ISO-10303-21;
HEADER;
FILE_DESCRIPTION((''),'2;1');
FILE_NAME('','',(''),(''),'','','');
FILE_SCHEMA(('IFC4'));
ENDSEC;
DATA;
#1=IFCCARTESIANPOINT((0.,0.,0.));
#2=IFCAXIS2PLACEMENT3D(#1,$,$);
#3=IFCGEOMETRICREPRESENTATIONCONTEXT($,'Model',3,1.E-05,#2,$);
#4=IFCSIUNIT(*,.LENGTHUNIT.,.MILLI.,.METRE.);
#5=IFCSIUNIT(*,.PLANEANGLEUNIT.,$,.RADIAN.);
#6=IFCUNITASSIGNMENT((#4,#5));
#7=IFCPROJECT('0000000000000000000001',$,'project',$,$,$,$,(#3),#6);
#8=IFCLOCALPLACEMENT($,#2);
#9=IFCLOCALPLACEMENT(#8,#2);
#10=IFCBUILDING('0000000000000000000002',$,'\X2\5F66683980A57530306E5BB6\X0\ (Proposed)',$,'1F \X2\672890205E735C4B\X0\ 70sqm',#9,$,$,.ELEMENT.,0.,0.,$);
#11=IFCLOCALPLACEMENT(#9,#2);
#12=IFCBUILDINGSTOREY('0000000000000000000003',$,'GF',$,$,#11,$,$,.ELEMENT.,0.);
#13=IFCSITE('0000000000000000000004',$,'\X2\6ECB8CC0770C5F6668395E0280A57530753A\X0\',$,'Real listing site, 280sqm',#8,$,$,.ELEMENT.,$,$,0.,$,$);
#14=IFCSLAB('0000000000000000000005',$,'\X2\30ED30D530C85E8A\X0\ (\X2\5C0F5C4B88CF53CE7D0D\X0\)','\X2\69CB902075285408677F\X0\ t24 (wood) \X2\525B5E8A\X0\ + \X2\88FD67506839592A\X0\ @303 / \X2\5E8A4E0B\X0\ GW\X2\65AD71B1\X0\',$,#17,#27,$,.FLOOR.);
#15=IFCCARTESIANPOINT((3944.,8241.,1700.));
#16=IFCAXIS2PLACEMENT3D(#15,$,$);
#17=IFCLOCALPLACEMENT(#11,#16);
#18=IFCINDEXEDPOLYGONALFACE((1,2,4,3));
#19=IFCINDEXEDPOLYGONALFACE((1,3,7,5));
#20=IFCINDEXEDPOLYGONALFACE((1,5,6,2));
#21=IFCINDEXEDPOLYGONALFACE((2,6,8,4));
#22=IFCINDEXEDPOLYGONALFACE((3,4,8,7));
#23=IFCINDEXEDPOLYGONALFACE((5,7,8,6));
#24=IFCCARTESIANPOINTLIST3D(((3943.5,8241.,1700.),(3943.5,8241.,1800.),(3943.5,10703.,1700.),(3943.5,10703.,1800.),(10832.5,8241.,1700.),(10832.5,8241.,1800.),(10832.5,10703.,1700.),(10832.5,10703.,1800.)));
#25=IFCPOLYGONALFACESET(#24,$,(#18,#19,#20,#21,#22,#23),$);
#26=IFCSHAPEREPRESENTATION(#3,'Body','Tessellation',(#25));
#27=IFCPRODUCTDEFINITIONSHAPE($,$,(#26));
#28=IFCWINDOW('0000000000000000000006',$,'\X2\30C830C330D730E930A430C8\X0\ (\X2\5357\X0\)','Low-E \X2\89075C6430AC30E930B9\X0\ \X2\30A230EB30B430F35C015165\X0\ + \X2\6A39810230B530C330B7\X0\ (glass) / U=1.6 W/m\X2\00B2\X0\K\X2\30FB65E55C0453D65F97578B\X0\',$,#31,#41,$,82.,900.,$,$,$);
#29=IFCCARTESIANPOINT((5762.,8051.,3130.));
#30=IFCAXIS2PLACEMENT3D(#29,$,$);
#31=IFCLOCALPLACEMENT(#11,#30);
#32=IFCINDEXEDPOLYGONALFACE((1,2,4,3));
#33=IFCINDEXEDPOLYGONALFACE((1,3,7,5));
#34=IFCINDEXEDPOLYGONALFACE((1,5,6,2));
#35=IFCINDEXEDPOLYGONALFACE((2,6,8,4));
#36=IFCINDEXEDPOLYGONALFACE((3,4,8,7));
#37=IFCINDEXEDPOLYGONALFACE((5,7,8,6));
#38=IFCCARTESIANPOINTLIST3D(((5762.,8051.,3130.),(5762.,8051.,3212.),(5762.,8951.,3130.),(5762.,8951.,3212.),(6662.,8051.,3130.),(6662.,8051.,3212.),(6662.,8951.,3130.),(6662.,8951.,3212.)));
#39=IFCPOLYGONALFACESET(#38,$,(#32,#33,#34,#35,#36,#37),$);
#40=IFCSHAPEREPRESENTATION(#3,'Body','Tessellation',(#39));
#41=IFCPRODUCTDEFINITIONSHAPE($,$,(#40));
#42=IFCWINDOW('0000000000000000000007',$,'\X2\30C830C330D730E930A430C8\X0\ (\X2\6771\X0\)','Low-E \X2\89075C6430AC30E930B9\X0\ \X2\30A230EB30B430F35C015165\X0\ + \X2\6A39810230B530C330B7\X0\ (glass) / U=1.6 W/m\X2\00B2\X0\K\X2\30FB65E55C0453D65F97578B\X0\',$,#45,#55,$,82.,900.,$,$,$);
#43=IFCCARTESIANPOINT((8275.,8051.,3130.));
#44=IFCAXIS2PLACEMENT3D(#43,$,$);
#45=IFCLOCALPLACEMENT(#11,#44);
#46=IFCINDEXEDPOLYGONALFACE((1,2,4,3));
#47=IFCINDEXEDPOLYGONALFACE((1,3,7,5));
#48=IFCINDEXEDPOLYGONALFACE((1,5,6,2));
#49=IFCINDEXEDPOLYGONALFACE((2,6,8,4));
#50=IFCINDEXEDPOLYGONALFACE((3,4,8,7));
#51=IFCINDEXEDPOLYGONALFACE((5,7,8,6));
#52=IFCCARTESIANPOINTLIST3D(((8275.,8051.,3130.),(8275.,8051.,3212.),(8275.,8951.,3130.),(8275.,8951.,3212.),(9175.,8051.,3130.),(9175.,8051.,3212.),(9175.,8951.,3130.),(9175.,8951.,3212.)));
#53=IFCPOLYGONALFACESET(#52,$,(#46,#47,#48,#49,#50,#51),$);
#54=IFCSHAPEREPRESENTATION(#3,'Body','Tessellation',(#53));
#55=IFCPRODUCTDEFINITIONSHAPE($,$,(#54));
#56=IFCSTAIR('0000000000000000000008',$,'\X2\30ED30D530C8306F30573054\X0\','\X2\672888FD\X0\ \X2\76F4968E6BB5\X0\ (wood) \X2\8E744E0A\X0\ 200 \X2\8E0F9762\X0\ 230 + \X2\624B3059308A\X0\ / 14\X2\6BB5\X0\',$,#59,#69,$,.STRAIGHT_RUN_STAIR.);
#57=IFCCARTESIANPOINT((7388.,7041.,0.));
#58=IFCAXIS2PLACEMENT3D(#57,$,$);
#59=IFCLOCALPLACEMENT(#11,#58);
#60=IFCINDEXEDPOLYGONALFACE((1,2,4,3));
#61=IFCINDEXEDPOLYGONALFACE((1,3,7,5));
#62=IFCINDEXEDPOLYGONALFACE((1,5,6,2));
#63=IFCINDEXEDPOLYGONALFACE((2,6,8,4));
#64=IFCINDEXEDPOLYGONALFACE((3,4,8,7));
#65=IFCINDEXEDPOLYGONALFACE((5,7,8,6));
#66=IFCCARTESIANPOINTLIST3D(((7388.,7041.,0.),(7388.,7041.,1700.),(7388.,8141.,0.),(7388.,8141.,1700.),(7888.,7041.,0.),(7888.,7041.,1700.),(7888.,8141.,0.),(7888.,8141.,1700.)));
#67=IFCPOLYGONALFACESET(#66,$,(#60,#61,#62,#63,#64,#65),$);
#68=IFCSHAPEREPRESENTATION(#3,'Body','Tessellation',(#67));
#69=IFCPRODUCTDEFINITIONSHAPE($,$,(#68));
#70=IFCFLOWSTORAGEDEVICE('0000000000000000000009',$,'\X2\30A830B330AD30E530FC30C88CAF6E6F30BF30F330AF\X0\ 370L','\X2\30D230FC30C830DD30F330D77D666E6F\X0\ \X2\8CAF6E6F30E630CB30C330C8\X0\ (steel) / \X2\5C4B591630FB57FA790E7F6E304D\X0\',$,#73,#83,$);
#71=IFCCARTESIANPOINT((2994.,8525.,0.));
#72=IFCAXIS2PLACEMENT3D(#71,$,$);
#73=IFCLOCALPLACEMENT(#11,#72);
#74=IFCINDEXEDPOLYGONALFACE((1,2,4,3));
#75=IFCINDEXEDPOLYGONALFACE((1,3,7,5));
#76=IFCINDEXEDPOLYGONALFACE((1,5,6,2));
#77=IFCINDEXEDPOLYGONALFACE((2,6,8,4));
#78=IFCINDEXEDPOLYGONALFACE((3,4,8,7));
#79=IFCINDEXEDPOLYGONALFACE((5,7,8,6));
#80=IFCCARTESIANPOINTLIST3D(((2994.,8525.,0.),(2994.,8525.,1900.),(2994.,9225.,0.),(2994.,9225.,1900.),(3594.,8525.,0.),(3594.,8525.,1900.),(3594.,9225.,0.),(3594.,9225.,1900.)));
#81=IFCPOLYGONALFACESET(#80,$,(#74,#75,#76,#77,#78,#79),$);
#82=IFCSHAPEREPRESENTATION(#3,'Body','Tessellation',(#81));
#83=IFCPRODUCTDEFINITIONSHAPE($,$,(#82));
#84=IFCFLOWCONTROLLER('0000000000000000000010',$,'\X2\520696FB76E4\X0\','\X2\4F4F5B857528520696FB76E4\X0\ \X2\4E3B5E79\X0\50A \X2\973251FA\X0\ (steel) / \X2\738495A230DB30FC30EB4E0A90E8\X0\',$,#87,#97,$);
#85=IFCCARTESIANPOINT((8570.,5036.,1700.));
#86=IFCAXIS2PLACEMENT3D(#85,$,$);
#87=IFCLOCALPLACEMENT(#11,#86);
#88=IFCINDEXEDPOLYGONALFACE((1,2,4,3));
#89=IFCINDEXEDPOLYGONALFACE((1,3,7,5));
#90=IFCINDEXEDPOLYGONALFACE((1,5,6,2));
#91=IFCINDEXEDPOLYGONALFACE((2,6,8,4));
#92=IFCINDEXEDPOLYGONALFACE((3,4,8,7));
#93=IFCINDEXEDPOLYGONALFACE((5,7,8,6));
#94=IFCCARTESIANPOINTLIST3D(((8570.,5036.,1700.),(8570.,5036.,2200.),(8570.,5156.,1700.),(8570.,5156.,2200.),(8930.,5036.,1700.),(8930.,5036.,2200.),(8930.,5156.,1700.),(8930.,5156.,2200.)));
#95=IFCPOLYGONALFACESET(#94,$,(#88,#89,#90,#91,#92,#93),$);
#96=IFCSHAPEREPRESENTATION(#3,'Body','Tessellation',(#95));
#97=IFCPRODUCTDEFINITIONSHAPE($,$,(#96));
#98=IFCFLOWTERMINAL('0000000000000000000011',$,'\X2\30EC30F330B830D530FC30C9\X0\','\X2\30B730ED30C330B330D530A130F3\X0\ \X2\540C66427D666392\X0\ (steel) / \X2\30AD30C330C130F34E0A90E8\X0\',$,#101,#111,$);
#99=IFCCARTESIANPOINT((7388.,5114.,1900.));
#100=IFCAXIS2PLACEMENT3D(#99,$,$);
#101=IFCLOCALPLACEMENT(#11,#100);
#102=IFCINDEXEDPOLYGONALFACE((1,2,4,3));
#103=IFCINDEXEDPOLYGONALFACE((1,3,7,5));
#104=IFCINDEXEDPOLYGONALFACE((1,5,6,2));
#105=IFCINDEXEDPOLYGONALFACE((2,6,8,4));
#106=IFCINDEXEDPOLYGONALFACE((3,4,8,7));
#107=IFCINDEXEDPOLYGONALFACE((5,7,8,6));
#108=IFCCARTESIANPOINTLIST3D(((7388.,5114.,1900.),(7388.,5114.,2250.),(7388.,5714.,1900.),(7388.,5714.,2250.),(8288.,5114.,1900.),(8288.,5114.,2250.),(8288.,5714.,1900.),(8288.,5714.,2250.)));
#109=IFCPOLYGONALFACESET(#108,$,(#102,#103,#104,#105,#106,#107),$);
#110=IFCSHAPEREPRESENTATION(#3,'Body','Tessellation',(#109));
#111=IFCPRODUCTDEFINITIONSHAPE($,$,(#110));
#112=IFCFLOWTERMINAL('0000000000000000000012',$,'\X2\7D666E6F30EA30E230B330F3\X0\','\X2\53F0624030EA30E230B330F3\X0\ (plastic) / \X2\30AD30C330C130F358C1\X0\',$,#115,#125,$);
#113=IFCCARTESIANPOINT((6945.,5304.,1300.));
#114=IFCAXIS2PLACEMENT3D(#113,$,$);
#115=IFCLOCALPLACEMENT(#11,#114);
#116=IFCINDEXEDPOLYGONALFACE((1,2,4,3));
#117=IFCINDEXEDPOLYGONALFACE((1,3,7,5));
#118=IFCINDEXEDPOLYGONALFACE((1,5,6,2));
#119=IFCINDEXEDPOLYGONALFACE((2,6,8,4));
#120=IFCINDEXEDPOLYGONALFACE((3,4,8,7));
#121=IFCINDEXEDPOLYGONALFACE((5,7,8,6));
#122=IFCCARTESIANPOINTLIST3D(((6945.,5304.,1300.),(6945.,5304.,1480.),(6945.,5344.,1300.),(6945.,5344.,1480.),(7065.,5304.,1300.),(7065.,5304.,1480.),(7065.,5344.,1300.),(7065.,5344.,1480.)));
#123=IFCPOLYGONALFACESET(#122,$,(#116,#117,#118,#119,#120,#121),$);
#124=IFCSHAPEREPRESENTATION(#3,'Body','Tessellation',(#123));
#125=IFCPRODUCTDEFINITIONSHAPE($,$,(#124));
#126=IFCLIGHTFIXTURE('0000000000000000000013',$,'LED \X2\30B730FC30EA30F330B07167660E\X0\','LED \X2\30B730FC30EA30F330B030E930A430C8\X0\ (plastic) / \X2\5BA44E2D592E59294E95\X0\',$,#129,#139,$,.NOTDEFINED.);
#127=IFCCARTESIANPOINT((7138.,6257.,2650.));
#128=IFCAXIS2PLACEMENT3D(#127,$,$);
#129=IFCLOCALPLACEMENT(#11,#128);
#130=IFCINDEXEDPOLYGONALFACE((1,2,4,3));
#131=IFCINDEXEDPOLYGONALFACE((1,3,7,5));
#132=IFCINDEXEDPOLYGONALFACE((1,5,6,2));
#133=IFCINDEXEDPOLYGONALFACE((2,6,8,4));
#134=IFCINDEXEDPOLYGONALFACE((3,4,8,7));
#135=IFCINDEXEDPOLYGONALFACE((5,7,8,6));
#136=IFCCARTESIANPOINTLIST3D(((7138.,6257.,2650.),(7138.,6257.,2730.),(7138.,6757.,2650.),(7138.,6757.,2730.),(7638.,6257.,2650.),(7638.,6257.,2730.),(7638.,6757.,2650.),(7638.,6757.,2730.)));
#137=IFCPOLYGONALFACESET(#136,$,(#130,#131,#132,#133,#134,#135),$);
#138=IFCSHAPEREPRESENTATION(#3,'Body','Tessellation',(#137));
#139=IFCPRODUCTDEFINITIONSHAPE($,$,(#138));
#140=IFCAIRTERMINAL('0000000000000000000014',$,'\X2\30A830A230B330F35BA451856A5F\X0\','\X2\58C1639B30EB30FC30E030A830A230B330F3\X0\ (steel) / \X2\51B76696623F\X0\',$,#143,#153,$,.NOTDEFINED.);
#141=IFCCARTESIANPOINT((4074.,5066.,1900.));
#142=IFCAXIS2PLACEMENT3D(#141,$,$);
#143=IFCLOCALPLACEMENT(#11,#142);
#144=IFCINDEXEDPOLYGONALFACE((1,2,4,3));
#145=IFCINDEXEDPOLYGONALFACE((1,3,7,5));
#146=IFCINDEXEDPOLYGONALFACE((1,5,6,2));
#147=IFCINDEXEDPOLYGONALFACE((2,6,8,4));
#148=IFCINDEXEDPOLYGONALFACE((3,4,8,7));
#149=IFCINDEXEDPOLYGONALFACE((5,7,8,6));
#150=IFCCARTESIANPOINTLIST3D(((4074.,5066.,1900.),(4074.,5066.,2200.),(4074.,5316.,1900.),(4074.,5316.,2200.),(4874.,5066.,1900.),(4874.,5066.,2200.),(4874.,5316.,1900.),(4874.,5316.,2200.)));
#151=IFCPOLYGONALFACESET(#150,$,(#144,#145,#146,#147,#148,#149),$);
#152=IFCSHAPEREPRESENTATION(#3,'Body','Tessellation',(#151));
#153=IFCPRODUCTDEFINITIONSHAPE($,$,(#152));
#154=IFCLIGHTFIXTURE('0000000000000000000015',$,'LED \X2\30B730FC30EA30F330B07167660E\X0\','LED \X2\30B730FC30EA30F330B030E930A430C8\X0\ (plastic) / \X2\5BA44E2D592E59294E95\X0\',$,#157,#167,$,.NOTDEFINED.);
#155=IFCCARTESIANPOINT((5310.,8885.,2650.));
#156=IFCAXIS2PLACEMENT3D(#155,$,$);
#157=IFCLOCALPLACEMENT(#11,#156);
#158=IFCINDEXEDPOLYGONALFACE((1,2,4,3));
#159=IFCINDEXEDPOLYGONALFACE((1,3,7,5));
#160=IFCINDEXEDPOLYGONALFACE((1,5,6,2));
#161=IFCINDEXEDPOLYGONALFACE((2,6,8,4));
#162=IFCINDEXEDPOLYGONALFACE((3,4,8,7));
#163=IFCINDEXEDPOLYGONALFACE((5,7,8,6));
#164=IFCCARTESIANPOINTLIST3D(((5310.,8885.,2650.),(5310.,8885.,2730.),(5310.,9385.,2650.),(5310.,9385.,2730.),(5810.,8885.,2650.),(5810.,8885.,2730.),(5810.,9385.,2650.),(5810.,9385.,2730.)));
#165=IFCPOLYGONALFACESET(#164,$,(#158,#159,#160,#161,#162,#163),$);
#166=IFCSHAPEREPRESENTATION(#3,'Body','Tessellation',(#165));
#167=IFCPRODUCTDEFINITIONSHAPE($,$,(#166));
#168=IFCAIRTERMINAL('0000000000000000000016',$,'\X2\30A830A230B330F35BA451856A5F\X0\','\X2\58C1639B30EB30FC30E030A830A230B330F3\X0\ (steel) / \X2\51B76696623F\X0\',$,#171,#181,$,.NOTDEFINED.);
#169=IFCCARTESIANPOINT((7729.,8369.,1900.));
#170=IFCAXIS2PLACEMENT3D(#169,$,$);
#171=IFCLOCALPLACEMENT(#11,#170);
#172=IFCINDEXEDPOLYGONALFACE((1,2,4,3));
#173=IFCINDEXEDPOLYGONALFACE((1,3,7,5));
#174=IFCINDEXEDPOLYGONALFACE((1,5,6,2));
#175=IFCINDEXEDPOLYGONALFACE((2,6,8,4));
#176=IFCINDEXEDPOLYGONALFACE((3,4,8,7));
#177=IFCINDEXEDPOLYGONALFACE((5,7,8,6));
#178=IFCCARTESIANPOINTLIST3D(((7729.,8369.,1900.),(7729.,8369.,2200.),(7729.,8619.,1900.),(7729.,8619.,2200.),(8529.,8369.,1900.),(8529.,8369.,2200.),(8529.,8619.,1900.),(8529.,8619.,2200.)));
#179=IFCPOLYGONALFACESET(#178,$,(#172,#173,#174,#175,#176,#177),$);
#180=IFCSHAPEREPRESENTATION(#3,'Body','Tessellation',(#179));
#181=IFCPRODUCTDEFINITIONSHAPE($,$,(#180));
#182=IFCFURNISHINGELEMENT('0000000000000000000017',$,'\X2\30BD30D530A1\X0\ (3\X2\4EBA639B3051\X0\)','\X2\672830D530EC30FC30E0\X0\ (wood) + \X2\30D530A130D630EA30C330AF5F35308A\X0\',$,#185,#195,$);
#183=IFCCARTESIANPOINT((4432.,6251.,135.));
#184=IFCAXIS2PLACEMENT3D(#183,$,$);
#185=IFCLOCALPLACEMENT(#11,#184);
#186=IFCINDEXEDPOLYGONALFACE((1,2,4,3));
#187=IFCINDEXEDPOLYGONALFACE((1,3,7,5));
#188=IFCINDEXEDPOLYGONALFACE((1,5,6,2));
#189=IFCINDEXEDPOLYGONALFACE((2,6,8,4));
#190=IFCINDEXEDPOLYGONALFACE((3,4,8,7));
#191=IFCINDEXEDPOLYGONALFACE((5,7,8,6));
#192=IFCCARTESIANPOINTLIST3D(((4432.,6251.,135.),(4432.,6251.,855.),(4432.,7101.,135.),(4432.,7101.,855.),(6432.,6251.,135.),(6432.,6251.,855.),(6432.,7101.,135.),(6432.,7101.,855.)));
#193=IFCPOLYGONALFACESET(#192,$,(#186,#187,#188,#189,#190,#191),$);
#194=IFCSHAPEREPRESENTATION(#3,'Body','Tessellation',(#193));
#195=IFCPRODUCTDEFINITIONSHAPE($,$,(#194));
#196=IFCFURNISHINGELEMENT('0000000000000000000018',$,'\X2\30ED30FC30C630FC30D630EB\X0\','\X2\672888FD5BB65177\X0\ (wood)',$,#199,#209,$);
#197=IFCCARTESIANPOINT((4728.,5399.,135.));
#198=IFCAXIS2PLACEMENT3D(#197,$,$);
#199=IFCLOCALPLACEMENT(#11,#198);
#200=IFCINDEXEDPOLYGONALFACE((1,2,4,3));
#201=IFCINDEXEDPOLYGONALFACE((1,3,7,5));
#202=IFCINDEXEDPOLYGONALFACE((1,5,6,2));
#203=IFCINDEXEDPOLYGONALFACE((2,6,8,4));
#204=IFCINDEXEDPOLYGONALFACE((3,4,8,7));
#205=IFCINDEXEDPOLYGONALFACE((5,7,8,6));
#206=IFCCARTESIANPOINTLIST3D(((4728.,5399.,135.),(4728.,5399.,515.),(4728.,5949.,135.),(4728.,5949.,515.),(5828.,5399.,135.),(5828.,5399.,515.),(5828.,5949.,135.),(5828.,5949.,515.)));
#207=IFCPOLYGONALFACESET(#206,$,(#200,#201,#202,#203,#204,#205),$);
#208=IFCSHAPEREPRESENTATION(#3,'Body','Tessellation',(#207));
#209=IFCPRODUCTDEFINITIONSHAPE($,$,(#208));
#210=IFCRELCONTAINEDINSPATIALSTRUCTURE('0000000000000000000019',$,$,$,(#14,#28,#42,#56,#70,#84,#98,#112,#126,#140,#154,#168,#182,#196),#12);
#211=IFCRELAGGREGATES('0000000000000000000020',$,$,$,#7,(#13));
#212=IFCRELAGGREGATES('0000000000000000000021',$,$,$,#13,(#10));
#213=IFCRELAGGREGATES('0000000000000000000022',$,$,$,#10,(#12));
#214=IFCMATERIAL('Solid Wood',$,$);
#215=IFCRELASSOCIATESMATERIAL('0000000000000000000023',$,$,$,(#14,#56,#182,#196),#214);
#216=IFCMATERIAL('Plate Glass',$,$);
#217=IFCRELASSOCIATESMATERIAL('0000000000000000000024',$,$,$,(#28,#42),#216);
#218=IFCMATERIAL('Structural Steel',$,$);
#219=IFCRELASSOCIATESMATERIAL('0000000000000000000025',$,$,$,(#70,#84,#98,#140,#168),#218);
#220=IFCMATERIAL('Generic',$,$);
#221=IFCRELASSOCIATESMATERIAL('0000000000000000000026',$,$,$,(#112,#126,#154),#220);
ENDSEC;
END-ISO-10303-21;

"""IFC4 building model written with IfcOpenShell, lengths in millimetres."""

from ifc_helpers import new_model, si_unit, frame, frame_2d, origin, place, context, project, spatial, rectangle, extrude, material, element, save


model = new_model("IFC4")

# Units and contexts
model_context = context("Model", 3, precision=1e-05, world=origin())
ifc_project = project(units=[si_unit("LENGTHUNIT", "METRE", prefix="MILLI"), si_unit("PLANEANGLEUNIT", "RADIAN")], contexts=[model_context])

# Site, building, storey
site_placement = place(None, origin())
site = spatial("IfcSite", under=ifc_project, at=site_placement, Name="滋賀県彦根市肥田町", ObjectType="Real listing site, 280sqm", CompositionType="ELEMENT", RefElevation=0.0)
building_placement = place(site_placement, origin())
building = spatial("IfcBuilding", under=site, at=building_placement, Name="彦根肥田の家 (Proposed)", ObjectType="1F 木造平屋 70sqm", CompositionType="ELEMENT", ElevationOfRefHeight=0.0, ElevationOfTerrain=0.0)
storey_placement = place(building_placement, origin())
storey = spatial("IfcBuildingStorey", under=building, at=storey_placement, Name="GF", CompositionType="ELEMENT", Elevation=0.0)

# Shared definitions
ifc_material_1 = material(Name="Solid Wood")

# Slab
slab_placement = place(storey_placement, frame((3944.0, 8241.0, 1700.0)))
element("IfcSlab", 1, at=slab_placement, inside=storey, material=ifc_material_1, Name="ロフト床 (小屋裏収納)", Description="構造用合板 t24 (wood) 剛床 + 製材根太 @303 / 床下 GW断熱", PredefinedType="FLOOR", context=model_context, shape_type="SweptSolid", body=[
    extrude(rectangle(XDim=6889.0, YDim=2462.0, at=frame_2d((3444.0, 1231.0))), frame((3944.0, 8241.0, 1700.0)), (0.0, 0.0, 1.0), 100.0),
])

# Windows
ifc_material_2 = material(Name="Plate Glass")
window_1_placement = place(storey_placement, frame((5762.0, 8051.0, 3130.0)))
element("IfcWindow", 2, at=window_1_placement, inside=storey, material=ifc_material_2, Name="トップライト (南)", Description="Low-E 複層ガラス アルゴン封入 + 樹脂サッシ (glass) / U=1.6 W/m²K・日射取得型", OverallHeight=82.0, OverallWidth=900.0, context=model_context, shape_type="SweptSolid", body=[
    extrude(rectangle(XDim=900.0, YDim=900.0, at=frame_2d((450.0, 450.0))), frame((5762.0, 8051.0, 3130.0)), (0.0, 0.0, 1.0), 82.0),
])
window_2_placement = place(storey_placement, frame((8275.0, 8051.0, 3130.0)))
element("IfcWindow", 3, at=window_2_placement, inside=storey, material=ifc_material_2, Name="トップライト (東)", Description="Low-E 複層ガラス アルゴン封入 + 樹脂サッシ (glass) / U=1.6 W/m²K・日射取得型", OverallHeight=82.0, OverallWidth=900.0, context=model_context, shape_type="SweptSolid", body=[
    extrude(rectangle(XDim=900.0, YDim=900.0, at=frame_2d((450.0, 450.0))), frame((8275.0, 8051.0, 3130.0)), (0.0, 0.0, 1.0), 82.0),
])

# Stair
stair_placement = place(storey_placement, frame((7388.0, 7041.0, 0.0)))
element("IfcStair", 4, at=stair_placement, inside=storey, material=ifc_material_1, Name="ロフトはしご", Description="木製 直階段 (wood) 蹴上 200 踏面 230 + 手すり / 14段", PredefinedType="STRAIGHT_RUN_STAIR", context=model_context, shape_type="SweptSolid", body=[
    extrude(rectangle(XDim=500.0, YDim=1100.0, at=frame_2d((250.0, 550.0))), frame((7388.0, 7041.0, 0.0)), (0.0, 0.0, 1.0), 1700.0),
])

# Flow storage device
ifc_material_3 = material(Name="Structural Steel")
flow_storage_device_placement = place(storey_placement, frame((2994.0, 8525.0, 0.0)))
element("IfcFlowStorageDevice", 5, at=flow_storage_device_placement, inside=storey, material=ifc_material_3, Name="エコキュート貯湯タンク 370L", Description="ヒートポンプ給湯 貯湯ユニット (steel) / 屋外・基礎置き", context=model_context, shape_type="SweptSolid", body=[
    extrude(rectangle(XDim=600.0, YDim=700.0, at=frame_2d((300.0, 350.0))), frame((2994.0, 8525.0, 0.0)), (0.0, 0.0, 1.0), 1900.0),
])

# Flow controller
flow_controller_placement = place(storey_placement, frame((8570.0, 5036.0, 1700.0)))
element("IfcFlowController", 6, at=flow_controller_placement, inside=storey, material=ifc_material_3, Name="分電盤", Description="住宅用分電盤 主幹50A 露出 (steel) / 玄関ホール上部", context=model_context, shape_type="SweptSolid", body=[
    extrude(rectangle(XDim=360.0, YDim=120.0, at=frame_2d((180.0, 60.0))), frame((8570.0, 5036.0, 1700.0)), (0.0, 0.0, 1.0), 500.0),
])

# Flow terminals
flow_terminal_1_placement = place(storey_placement, frame((7388.0, 5114.0, 1900.0)))
element("IfcFlowTerminal", 7, at=flow_terminal_1_placement, inside=storey, material=ifc_material_3, Name="レンジフード", Description="シロッコファン 同時給排 (steel) / キッチン上部", context=model_context, shape_type="SweptSolid", body=[
    extrude(rectangle(XDim=900.0, YDim=600.0, at=frame_2d((450.0, 300.0))), frame((7388.0, 5114.0, 1900.0)), (0.0, 0.0, 1.0), 350.0),
])
ifc_material_4 = material(Name="Generic")
flow_terminal_2_placement = place(storey_placement, frame((6945.0, 5304.0, 1300.0)))
element("IfcFlowTerminal", 8, at=flow_terminal_2_placement, inside=storey, material=ifc_material_4, Name="給湯リモコン", Description="台所リモコン (plastic) / キッチン壁", context=model_context, shape_type="SweptSolid", body=[
    extrude(rectangle(XDim=120.0, YDim=40.0, at=frame_2d((60.0, 20.0))), frame((6945.0, 5304.0, 1300.0)), (0.0, 0.0, 1.0), 180.0),
])

# Light fixture
light_fixture_1_placement = place(storey_placement, frame((7138.0, 6257.0, 2650.0)))
element("IfcLightFixture", 9, at=light_fixture_1_placement, inside=storey, material=ifc_material_4, Name="LED シーリング照明", Description="LED シーリングライト (plastic) / 室中央天井", PredefinedType="NOTDEFINED", context=model_context, shape_type="SweptSolid", body=[
    extrude(rectangle(XDim=500.0, YDim=500.0, at=frame_2d((250.0, 250.0))), frame((7138.0, 6257.0, 2650.0)), (0.0, 0.0, 1.0), 80.0),
])

# Air terminal
air_terminal_1_placement = place(storey_placement, frame((4074.0, 5066.0, 1900.0)))
element("IfcAirTerminal", 10, at=air_terminal_1_placement, inside=storey, material=ifc_material_3, Name="エアコン室内機", Description="壁掛ルームエアコン (steel) / 冷暖房", PredefinedType="NOTDEFINED", context=model_context, shape_type="SweptSolid", body=[
    extrude(rectangle(XDim=800.0, YDim=250.0, at=frame_2d((400.0, 125.0))), frame((4074.0, 5066.0, 1900.0)), (0.0, 0.0, 1.0), 300.0),
])

# Light fixture
light_fixture_2_placement = place(storey_placement, frame((5310.0, 8885.0, 2650.0)))
element("IfcLightFixture", 11, at=light_fixture_2_placement, inside=storey, material=ifc_material_4, Name="LED シーリング照明", Description="LED シーリングライト (plastic) / 室中央天井", PredefinedType="NOTDEFINED", context=model_context, shape_type="SweptSolid", body=[
    extrude(rectangle(XDim=500.0, YDim=500.0, at=frame_2d((250.0, 250.0))), frame((5310.0, 8885.0, 2650.0)), (0.0, 0.0, 1.0), 80.0),
])

# Air terminal
air_terminal_2_placement = place(storey_placement, frame((7729.0, 8369.0, 1900.0)))
element("IfcAirTerminal", 12, at=air_terminal_2_placement, inside=storey, material=ifc_material_3, Name="エアコン室内機", Description="壁掛ルームエアコン (steel) / 冷暖房", PredefinedType="NOTDEFINED", context=model_context, shape_type="SweptSolid", body=[
    extrude(rectangle(XDim=800.0, YDim=250.0, at=frame_2d((400.0, 125.0))), frame((7729.0, 8369.0, 1900.0)), (0.0, 0.0, 1.0), 300.0),
])

# Furnishing elements
furnishing_1_placement = place(storey_placement, frame((4432.0, 6251.0, 135.0)))
element("IfcFurnishingElement", 13, at=furnishing_1_placement, inside=storey, material=ifc_material_1, Name="ソファ (3人掛け)", Description="木フレーム (wood) + ファブリック張り", context=model_context, shape_type="SweptSolid", body=[
    extrude(rectangle(XDim=2000.0, YDim=850.0, at=frame_2d((1000.0, 425.0))), frame((4432.0, 6251.0, 135.0)), (0.0, 0.0, 1.0), 720.0),
])
furnishing_2_placement = place(storey_placement, frame((4728.0, 5399.0, 135.0)))
element("IfcFurnishingElement", 14, at=furnishing_2_placement, inside=storey, material=ifc_material_1, Name="ローテーブル", Description="木製家具 (wood)", context=model_context, shape_type="SweptSolid", body=[
    extrude(rectangle(XDim=1100.0, YDim=550.0, at=frame_2d((550.0, 275.0))), frame((4728.0, 5399.0, 135.0)), (0.0, 0.0, 1.0), 380.0),
])

save(model, "model.ifc")
